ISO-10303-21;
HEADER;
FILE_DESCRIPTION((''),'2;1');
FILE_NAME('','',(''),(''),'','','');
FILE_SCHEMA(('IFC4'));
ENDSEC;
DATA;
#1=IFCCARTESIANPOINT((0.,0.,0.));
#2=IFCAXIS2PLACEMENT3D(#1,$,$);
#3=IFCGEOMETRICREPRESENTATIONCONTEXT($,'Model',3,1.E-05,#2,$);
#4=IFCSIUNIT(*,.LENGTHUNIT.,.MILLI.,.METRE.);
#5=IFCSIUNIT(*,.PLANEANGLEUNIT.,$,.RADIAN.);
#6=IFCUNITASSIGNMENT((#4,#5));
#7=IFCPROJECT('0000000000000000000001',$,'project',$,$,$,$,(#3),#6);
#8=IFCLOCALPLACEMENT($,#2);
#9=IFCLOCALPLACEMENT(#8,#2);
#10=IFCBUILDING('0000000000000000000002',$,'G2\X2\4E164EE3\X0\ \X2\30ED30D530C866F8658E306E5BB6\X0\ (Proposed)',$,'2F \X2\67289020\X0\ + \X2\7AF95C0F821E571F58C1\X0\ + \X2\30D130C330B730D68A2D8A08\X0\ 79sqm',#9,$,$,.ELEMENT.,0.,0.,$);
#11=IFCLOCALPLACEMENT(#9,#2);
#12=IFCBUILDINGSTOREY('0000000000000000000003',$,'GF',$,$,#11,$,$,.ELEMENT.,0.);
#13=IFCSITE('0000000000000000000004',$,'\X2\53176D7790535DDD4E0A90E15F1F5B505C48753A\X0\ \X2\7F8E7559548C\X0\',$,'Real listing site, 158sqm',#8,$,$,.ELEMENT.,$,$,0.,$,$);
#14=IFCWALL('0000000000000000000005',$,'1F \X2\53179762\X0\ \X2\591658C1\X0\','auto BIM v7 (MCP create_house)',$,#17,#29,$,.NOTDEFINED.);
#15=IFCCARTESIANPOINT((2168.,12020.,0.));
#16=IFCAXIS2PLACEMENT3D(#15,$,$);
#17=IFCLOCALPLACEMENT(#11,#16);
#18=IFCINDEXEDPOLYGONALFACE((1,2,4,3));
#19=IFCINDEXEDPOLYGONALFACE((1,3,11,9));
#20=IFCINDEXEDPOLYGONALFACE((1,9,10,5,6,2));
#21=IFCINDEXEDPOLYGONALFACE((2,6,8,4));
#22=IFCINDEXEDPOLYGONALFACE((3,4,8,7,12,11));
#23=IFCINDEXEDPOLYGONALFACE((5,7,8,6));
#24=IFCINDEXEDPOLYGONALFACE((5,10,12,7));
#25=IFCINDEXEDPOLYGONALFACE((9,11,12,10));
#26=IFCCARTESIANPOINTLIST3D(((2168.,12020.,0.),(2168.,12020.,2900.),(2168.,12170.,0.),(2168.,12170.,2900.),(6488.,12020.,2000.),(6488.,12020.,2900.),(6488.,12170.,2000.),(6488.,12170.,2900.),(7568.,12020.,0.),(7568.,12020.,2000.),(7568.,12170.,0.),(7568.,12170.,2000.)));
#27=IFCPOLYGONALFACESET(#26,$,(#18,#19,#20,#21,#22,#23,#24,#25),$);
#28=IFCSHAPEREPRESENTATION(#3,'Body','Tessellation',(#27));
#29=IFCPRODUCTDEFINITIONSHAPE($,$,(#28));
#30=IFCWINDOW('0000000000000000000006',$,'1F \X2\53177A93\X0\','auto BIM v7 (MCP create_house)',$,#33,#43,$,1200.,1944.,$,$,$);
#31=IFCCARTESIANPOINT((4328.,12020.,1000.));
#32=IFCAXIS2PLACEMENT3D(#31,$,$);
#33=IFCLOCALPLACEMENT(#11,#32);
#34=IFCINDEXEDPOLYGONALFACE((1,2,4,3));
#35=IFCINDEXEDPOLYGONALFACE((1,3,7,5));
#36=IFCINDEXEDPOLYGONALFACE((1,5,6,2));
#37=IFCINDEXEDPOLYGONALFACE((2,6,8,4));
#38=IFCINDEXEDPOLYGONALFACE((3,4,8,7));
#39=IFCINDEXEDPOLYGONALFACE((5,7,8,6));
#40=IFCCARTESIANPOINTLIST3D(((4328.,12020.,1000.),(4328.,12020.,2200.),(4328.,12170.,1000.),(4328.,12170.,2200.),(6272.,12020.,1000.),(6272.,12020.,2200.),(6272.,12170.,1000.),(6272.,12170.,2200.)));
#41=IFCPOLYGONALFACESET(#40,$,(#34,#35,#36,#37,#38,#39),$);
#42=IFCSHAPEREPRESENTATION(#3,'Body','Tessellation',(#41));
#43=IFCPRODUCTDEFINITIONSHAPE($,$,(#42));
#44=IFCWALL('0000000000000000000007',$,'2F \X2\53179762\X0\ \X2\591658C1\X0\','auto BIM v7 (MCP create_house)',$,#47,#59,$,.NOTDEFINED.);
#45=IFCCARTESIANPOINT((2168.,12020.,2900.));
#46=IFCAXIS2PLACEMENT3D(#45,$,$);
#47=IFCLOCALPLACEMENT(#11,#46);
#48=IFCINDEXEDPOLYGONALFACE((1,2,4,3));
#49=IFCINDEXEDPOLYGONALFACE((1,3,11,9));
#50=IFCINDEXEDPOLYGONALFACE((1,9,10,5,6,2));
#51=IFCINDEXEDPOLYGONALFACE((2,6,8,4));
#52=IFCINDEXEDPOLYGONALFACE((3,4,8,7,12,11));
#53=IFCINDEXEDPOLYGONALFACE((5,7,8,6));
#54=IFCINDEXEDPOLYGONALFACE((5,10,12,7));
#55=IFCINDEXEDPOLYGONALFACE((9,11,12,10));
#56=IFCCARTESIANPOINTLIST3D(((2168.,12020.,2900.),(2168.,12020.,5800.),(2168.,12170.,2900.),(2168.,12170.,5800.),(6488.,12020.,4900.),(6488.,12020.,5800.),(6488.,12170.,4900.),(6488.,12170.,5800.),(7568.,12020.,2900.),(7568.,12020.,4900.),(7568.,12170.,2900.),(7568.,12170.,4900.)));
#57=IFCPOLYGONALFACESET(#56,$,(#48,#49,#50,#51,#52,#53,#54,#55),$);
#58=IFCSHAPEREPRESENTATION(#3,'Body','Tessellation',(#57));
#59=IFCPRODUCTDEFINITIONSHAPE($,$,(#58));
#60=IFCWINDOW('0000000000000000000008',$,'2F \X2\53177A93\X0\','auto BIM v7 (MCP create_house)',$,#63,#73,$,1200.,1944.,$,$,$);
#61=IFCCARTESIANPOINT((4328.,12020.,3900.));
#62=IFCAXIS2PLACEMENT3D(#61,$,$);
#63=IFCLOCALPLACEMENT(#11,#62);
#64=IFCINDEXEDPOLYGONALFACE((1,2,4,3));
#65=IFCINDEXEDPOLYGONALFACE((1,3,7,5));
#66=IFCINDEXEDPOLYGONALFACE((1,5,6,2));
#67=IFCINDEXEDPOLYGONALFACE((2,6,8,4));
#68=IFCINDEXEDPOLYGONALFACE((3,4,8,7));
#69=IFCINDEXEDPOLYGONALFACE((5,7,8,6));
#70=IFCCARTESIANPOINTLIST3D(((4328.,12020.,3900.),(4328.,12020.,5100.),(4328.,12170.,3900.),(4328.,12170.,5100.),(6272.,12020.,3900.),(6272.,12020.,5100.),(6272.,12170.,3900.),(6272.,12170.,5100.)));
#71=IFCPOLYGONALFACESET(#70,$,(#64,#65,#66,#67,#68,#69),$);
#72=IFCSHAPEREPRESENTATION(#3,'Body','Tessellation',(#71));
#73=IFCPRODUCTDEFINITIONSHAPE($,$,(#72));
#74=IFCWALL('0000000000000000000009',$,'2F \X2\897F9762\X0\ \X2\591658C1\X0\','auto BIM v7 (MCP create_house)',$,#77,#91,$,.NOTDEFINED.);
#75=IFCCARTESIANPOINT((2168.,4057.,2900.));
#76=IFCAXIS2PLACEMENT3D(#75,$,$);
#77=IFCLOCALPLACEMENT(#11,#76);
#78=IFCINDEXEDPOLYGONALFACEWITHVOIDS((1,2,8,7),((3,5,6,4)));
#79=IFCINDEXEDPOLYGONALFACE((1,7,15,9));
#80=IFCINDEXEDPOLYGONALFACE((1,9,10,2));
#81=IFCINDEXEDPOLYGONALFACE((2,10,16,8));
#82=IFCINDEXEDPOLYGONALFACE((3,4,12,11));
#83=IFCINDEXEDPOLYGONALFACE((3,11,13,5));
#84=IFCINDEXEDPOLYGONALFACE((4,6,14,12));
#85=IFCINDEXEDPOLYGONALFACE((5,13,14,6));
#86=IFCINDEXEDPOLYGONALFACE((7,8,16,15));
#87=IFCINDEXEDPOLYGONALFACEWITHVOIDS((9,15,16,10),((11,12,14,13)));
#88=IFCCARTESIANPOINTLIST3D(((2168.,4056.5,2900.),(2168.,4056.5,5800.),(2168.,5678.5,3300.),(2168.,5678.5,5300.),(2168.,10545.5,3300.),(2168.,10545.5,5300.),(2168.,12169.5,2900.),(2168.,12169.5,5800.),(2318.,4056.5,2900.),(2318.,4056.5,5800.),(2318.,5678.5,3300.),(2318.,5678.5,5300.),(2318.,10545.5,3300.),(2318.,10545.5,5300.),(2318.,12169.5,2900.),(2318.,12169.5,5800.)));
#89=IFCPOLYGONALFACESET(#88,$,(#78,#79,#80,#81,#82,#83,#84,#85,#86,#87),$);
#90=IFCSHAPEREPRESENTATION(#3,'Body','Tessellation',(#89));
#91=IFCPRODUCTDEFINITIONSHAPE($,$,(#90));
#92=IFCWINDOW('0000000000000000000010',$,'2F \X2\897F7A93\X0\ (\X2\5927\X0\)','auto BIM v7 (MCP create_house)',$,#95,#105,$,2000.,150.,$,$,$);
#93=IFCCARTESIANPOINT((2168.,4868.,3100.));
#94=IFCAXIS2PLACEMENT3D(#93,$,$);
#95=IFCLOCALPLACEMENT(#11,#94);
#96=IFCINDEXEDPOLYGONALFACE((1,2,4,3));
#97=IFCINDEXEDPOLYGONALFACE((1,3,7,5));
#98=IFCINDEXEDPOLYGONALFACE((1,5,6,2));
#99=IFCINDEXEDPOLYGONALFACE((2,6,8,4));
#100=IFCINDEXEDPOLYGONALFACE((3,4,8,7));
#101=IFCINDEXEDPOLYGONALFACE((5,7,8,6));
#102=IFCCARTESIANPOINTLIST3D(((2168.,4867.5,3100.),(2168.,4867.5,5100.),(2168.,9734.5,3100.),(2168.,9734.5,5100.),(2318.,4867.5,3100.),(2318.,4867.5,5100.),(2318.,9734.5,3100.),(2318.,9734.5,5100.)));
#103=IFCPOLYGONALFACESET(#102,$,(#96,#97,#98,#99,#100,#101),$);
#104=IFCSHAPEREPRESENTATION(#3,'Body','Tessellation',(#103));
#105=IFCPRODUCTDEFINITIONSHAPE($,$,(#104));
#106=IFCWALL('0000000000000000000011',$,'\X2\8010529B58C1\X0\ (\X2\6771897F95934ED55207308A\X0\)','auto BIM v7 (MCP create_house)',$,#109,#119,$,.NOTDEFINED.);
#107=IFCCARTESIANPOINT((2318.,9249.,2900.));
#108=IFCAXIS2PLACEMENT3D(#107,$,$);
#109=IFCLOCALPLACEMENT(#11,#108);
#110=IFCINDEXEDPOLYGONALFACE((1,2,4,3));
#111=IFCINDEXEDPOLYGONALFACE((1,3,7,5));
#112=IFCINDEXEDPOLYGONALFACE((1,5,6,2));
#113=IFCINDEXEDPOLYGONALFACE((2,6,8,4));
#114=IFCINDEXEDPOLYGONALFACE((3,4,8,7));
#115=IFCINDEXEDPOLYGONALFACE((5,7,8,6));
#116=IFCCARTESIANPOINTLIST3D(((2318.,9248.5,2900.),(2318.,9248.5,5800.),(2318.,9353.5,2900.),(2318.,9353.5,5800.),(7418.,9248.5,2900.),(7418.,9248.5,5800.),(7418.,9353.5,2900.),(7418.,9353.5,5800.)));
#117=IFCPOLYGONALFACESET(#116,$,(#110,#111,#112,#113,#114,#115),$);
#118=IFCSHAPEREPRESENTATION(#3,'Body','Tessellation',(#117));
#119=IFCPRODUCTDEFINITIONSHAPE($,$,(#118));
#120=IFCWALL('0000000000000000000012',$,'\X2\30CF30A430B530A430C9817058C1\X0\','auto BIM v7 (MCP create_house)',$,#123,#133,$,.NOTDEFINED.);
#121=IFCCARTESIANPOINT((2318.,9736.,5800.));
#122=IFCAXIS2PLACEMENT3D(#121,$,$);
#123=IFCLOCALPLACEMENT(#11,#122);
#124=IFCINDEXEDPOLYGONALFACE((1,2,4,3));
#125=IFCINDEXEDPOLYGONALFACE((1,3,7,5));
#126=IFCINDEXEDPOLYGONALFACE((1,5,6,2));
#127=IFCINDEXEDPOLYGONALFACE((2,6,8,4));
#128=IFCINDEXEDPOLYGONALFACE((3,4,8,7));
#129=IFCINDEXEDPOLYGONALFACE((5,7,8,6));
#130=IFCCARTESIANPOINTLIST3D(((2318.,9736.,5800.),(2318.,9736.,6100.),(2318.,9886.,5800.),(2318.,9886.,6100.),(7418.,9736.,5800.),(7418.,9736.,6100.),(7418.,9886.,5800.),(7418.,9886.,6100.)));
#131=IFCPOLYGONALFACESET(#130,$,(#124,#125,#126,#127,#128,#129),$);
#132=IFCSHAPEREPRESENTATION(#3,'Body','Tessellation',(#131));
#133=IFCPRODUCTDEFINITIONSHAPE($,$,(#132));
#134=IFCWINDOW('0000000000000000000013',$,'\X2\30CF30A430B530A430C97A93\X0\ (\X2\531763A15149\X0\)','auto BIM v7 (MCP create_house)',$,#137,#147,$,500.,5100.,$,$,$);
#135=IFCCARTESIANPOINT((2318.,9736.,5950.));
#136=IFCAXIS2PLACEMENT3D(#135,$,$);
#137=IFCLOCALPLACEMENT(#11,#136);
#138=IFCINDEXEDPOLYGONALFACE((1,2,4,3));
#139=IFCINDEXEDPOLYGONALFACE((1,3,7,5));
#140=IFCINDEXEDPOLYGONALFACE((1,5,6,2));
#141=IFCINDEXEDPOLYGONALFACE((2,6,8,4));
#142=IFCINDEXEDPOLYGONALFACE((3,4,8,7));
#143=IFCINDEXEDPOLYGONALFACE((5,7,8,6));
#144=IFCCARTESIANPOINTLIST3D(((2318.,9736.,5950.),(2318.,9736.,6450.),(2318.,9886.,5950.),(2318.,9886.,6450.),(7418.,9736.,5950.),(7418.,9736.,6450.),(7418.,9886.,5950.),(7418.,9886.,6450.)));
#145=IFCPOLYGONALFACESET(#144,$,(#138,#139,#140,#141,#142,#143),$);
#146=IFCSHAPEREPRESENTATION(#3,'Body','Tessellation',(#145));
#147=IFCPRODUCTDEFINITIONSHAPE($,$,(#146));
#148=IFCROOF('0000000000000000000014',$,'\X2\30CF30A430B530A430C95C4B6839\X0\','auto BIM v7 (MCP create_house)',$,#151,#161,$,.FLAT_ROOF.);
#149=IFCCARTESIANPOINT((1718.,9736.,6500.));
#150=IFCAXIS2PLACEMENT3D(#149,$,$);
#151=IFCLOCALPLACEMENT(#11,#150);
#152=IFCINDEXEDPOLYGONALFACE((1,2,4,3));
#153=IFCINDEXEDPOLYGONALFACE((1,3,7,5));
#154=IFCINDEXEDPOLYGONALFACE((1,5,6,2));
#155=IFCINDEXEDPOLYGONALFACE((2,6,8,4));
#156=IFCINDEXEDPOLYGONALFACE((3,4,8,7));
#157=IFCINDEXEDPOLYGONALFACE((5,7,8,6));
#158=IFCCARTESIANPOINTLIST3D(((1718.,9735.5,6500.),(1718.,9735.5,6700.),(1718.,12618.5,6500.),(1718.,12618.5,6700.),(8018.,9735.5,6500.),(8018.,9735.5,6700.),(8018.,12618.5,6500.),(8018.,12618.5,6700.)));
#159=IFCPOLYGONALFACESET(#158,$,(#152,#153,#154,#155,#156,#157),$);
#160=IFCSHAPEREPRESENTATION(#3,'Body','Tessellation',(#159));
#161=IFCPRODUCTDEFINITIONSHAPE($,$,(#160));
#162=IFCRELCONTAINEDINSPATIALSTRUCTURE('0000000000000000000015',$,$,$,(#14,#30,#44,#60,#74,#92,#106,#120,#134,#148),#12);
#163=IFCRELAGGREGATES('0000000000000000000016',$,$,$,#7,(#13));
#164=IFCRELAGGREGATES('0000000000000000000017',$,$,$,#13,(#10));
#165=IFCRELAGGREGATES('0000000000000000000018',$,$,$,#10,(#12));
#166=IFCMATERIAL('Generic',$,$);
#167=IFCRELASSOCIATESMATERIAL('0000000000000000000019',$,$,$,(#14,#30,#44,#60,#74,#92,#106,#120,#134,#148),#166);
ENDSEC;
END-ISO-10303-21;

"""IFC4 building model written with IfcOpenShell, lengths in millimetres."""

from ifc_helpers import new_model, si_unit, frame, frame_2d, origin, place, context, project, spatial, rectangle, extrude, material, element, fill, save


model = new_model("IFC4")

# Units and contexts
model_context = context("Model", 3, precision=1e-05, world=origin())
ifc_project = project(units=[si_unit("LENGTHUNIT", "METRE", prefix="MILLI"), si_unit("PLANEANGLEUNIT", "RADIAN")], contexts=[model_context])

# Site, building, storey
site_placement = place(None, origin())
site = spatial("IfcSite", under=ifc_project, at=site_placement, Name="北海道川上郡弟子屈町 美留和", ObjectType="Real listing site, 158sqm", CompositionType="ELEMENT", RefElevation=0.0)
building_placement = place(site_placement, origin())
building = spatial("IfcBuilding", under=site, at=building_placement, Name="G2世代 ロフト書斎の家 (Proposed)", ObjectType="2F 木造 + 竹小舞土壁 + パッシブ設計 79sqm", CompositionType="ELEMENT", ElevationOfRefHeight=0.0, ElevationOfTerrain=0.0)
storey_placement = place(building_placement, origin())
storey = spatial("IfcBuildingStorey", under=building, at=storey_placement, Name="GF", CompositionType="ELEMENT", Elevation=0.0)

# Wall, opening, window
ifc_material = material(Name="Generic")
wall_1_placement = place(storey_placement, frame((2168.0, 12020.0, 0.0)))
wall_1 = element("IfcWall", 1, at=wall_1_placement, inside=storey, material=ifc_material, Name="1F 北面 外壁", Description="auto BIM v7 (MCP create_house)", PredefinedType="NOTDEFINED", context=model_context, shape_type="SweptSolid", body=[
    extrude(rectangle(XDim=5400.0, YDim=150.0, at=frame_2d((2700.0, 75.0))), frame((2168.0, 12020.0, 0.0)), (0.0, 0.0, 1.0), 2900.0),
])
opening_1_placement = place(storey_placement, frame((4328.0, 12020.0, 1000.0)))
opening_1 = element("IfcOpeningElement", 2, at=opening_1_placement, cuts=wall_1, PredefinedType="NOTDEFINED", context=model_context, shape_type="SweptSolid", body=[
    extrude(rectangle(XDim=1944.0, YDim=150.0, at=frame_2d((972.0, 75.0))), frame((4328.0, 12020.0, 1000.0)), (0.0, 0.0, 1.0), 1200.0),
])
window_1_placement = place(storey_placement, frame((4328.0, 12020.0, 1000.0)))
window_1 = element("IfcWindow", 3, at=window_1_placement, inside=storey, material=ifc_material, Name="1F 北窓", Description="auto BIM v7 (MCP create_house)", OverallHeight=1200.0, OverallWidth=1944.0, context=model_context, shape_type="SweptSolid", body=[
    extrude(rectangle(XDim=1944.0, YDim=150.0, at=frame_2d((972.0, 75.0))), frame((4328.0, 12020.0, 1000.0)), (0.0, 0.0, 1.0), 1200.0),
])
fill(opening_1, window_1)

# Walls, openings, windows
wall_2_placement = place(storey_placement, frame((2168.0, 12020.0, 2900.0)))
wall_2 = element("IfcWall", 4, at=wall_2_placement, inside=storey, material=ifc_material, Name="2F 北面 外壁", Description="auto BIM v7 (MCP create_house)", PredefinedType="NOTDEFINED", context=model_context, shape_type="SweptSolid", body=[
    extrude(rectangle(XDim=5400.0, YDim=150.0, at=frame_2d((2700.0, 75.0))), frame((2168.0, 12020.0, 2900.0)), (0.0, 0.0, 1.0), 2900.0),
])
opening_2_placement = place(storey_placement, frame((4328.0, 12020.0, 3900.0)))
opening_2 = element("IfcOpeningElement", 5, at=opening_2_placement, cuts=wall_2, PredefinedType="NOTDEFINED", context=model_context, shape_type="SweptSolid", body=[
    extrude(rectangle(XDim=1944.0, YDim=150.0, at=frame_2d((972.0, 75.0))), frame((4328.0, 12020.0, 3900.0)), (0.0, 0.0, 1.0), 1200.0),
])
window_2_placement = place(storey_placement, frame((4328.0, 12020.0, 3900.0)))
window_2 = element("IfcWindow", 6, at=window_2_placement, inside=storey, material=ifc_material, Name="2F 北窓", Description="auto BIM v7 (MCP create_house)", OverallHeight=1200.0, OverallWidth=1944.0, context=model_context, shape_type="SweptSolid", body=[
    extrude(rectangle(XDim=1944.0, YDim=150.0, at=frame_2d((972.0, 75.0))), frame((4328.0, 12020.0, 3900.0)), (0.0, 0.0, 1.0), 1200.0),
])
fill(opening_2, window_2)
wall_3_placement = place(storey_placement, frame((2168.0, 4057.0, 2900.0)))
wall_3 = element("IfcWall", 7, at=wall_3_placement, inside=storey, material=ifc_material, Name="2F 西面 外壁", Description="auto BIM v7 (MCP create_house)", PredefinedType="NOTDEFINED", context=model_context, shape_type="SweptSolid", body=[
    extrude(rectangle(XDim=150.0, YDim=8113.0, at=frame_2d((75.0, 4056.0))), frame((2168.0, 4057.0, 2900.0)), (0.0, 0.0, 1.0), 2900.0),
])
opening_3_placement = place(storey_placement, frame((2168.0, 4868.0, 3100.0)))
opening_3 = element("IfcOpeningElement", 8, at=opening_3_placement, cuts=wall_3, PredefinedType="NOTDEFINED", context=model_context, shape_type="SweptSolid", body=[
    extrude(rectangle(XDim=150.0, YDim=4867.0, at=frame_2d((75.0, 2433.0))), frame((2168.0, 4868.0, 3100.0)), (0.0, 0.0, 1.0), 2000.0),
])
window_3_placement = place(storey_placement, frame((2168.0, 4868.0, 3100.0)))
window_3 = element("IfcWindow", 9, at=window_3_placement, inside=storey, material=ifc_material, Name="2F 西窓 (大)", Description="auto BIM v7 (MCP create_house)", OverallHeight=2000.0, OverallWidth=150.0, context=model_context, shape_type="SweptSolid", body=[
    extrude(rectangle(XDim=150.0, YDim=4867.0, at=frame_2d((75.0, 2433.0))), frame((2168.0, 4868.0, 3100.0)), (0.0, 0.0, 1.0), 2000.0),
])
fill(opening_3, window_3)

# Wall
wall_4_placement = place(storey_placement, frame((2318.0, 9249.0, 2900.0)))
element("IfcWall", 10, at=wall_4_placement, inside=storey, material=ifc_material, Name="耐力壁 (東西間仕切り)", Description="auto BIM v7 (MCP create_house)", PredefinedType="NOTDEFINED", context=model_context, shape_type="SweptSolid", body=[
    extrude(rectangle(XDim=5100.0, YDim=105.0, at=frame_2d((2550.0, 52.0))), frame((2318.0, 9249.0, 2900.0)), (0.0, 0.0, 1.0), 2900.0),
])

# Wall, opening, window
wall_5_placement = place(storey_placement, frame((2318.0, 9736.0, 5800.0)))
wall_5 = element("IfcWall", 11, at=wall_5_placement, inside=storey, material=ifc_material, Name="ハイサイド腰壁", Description="auto BIM v7 (MCP create_house)", PredefinedType="NOTDEFINED", context=model_context, shape_type="SweptSolid", body=[
    extrude(rectangle(XDim=5100.0, YDim=150.0, at=frame_2d((2550.0, 75.0))), frame((2318.0, 9736.0, 5800.0)), (0.0, 0.0, 1.0), 700.0),
])
opening_4_placement = place(storey_placement, frame((2318.0, 9736.0, 5950.0)))
opening_4 = element("IfcOpeningElement", 12, at=opening_4_placement, cuts=wall_5, PredefinedType="NOTDEFINED", context=model_context, shape_type="SweptSolid", body=[
    extrude(rectangle(XDim=5100.0, YDim=150.0, at=frame_2d((2550.0, 75.0))), frame((2318.0, 9736.0, 5950.0)), (0.0, 0.0, 1.0), 500.0),
])
window_4_placement = place(storey_placement, frame((2318.0, 9736.0, 5950.0)))
window_4 = element("IfcWindow", 13, at=window_4_placement, inside=storey, material=ifc_material, Name="ハイサイド窓 (北採光)", Description="auto BIM v7 (MCP create_house)", OverallHeight=500.0, OverallWidth=5100.0, context=model_context, shape_type="SweptSolid", body=[
    extrude(rectangle(XDim=5100.0, YDim=150.0, at=frame_2d((2550.0, 75.0))), frame((2318.0, 9736.0, 5950.0)), (0.0, 0.0, 1.0), 500.0),
])
fill(opening_4, window_4)

# Roof
roof_placement = place(storey_placement, frame((1718.0, 9736.0, 6500.0)))
element("IfcRoof", 14, at=roof_placement, inside=storey, material=ifc_material, Name="ハイサイド屋根", Description="auto BIM v7 (MCP create_house)", PredefinedType="FLAT_ROOF", context=model_context, shape_type="SweptSolid", body=[
    extrude(rectangle(XDim=6300.0, YDim=2883.0, at=frame_2d((3150.0, 1441.0))), frame((1718.0, 9736.0, 6500.0)), (0.0, 0.0, 1.0), 200.0),
])

save(model, "model.ifc")
